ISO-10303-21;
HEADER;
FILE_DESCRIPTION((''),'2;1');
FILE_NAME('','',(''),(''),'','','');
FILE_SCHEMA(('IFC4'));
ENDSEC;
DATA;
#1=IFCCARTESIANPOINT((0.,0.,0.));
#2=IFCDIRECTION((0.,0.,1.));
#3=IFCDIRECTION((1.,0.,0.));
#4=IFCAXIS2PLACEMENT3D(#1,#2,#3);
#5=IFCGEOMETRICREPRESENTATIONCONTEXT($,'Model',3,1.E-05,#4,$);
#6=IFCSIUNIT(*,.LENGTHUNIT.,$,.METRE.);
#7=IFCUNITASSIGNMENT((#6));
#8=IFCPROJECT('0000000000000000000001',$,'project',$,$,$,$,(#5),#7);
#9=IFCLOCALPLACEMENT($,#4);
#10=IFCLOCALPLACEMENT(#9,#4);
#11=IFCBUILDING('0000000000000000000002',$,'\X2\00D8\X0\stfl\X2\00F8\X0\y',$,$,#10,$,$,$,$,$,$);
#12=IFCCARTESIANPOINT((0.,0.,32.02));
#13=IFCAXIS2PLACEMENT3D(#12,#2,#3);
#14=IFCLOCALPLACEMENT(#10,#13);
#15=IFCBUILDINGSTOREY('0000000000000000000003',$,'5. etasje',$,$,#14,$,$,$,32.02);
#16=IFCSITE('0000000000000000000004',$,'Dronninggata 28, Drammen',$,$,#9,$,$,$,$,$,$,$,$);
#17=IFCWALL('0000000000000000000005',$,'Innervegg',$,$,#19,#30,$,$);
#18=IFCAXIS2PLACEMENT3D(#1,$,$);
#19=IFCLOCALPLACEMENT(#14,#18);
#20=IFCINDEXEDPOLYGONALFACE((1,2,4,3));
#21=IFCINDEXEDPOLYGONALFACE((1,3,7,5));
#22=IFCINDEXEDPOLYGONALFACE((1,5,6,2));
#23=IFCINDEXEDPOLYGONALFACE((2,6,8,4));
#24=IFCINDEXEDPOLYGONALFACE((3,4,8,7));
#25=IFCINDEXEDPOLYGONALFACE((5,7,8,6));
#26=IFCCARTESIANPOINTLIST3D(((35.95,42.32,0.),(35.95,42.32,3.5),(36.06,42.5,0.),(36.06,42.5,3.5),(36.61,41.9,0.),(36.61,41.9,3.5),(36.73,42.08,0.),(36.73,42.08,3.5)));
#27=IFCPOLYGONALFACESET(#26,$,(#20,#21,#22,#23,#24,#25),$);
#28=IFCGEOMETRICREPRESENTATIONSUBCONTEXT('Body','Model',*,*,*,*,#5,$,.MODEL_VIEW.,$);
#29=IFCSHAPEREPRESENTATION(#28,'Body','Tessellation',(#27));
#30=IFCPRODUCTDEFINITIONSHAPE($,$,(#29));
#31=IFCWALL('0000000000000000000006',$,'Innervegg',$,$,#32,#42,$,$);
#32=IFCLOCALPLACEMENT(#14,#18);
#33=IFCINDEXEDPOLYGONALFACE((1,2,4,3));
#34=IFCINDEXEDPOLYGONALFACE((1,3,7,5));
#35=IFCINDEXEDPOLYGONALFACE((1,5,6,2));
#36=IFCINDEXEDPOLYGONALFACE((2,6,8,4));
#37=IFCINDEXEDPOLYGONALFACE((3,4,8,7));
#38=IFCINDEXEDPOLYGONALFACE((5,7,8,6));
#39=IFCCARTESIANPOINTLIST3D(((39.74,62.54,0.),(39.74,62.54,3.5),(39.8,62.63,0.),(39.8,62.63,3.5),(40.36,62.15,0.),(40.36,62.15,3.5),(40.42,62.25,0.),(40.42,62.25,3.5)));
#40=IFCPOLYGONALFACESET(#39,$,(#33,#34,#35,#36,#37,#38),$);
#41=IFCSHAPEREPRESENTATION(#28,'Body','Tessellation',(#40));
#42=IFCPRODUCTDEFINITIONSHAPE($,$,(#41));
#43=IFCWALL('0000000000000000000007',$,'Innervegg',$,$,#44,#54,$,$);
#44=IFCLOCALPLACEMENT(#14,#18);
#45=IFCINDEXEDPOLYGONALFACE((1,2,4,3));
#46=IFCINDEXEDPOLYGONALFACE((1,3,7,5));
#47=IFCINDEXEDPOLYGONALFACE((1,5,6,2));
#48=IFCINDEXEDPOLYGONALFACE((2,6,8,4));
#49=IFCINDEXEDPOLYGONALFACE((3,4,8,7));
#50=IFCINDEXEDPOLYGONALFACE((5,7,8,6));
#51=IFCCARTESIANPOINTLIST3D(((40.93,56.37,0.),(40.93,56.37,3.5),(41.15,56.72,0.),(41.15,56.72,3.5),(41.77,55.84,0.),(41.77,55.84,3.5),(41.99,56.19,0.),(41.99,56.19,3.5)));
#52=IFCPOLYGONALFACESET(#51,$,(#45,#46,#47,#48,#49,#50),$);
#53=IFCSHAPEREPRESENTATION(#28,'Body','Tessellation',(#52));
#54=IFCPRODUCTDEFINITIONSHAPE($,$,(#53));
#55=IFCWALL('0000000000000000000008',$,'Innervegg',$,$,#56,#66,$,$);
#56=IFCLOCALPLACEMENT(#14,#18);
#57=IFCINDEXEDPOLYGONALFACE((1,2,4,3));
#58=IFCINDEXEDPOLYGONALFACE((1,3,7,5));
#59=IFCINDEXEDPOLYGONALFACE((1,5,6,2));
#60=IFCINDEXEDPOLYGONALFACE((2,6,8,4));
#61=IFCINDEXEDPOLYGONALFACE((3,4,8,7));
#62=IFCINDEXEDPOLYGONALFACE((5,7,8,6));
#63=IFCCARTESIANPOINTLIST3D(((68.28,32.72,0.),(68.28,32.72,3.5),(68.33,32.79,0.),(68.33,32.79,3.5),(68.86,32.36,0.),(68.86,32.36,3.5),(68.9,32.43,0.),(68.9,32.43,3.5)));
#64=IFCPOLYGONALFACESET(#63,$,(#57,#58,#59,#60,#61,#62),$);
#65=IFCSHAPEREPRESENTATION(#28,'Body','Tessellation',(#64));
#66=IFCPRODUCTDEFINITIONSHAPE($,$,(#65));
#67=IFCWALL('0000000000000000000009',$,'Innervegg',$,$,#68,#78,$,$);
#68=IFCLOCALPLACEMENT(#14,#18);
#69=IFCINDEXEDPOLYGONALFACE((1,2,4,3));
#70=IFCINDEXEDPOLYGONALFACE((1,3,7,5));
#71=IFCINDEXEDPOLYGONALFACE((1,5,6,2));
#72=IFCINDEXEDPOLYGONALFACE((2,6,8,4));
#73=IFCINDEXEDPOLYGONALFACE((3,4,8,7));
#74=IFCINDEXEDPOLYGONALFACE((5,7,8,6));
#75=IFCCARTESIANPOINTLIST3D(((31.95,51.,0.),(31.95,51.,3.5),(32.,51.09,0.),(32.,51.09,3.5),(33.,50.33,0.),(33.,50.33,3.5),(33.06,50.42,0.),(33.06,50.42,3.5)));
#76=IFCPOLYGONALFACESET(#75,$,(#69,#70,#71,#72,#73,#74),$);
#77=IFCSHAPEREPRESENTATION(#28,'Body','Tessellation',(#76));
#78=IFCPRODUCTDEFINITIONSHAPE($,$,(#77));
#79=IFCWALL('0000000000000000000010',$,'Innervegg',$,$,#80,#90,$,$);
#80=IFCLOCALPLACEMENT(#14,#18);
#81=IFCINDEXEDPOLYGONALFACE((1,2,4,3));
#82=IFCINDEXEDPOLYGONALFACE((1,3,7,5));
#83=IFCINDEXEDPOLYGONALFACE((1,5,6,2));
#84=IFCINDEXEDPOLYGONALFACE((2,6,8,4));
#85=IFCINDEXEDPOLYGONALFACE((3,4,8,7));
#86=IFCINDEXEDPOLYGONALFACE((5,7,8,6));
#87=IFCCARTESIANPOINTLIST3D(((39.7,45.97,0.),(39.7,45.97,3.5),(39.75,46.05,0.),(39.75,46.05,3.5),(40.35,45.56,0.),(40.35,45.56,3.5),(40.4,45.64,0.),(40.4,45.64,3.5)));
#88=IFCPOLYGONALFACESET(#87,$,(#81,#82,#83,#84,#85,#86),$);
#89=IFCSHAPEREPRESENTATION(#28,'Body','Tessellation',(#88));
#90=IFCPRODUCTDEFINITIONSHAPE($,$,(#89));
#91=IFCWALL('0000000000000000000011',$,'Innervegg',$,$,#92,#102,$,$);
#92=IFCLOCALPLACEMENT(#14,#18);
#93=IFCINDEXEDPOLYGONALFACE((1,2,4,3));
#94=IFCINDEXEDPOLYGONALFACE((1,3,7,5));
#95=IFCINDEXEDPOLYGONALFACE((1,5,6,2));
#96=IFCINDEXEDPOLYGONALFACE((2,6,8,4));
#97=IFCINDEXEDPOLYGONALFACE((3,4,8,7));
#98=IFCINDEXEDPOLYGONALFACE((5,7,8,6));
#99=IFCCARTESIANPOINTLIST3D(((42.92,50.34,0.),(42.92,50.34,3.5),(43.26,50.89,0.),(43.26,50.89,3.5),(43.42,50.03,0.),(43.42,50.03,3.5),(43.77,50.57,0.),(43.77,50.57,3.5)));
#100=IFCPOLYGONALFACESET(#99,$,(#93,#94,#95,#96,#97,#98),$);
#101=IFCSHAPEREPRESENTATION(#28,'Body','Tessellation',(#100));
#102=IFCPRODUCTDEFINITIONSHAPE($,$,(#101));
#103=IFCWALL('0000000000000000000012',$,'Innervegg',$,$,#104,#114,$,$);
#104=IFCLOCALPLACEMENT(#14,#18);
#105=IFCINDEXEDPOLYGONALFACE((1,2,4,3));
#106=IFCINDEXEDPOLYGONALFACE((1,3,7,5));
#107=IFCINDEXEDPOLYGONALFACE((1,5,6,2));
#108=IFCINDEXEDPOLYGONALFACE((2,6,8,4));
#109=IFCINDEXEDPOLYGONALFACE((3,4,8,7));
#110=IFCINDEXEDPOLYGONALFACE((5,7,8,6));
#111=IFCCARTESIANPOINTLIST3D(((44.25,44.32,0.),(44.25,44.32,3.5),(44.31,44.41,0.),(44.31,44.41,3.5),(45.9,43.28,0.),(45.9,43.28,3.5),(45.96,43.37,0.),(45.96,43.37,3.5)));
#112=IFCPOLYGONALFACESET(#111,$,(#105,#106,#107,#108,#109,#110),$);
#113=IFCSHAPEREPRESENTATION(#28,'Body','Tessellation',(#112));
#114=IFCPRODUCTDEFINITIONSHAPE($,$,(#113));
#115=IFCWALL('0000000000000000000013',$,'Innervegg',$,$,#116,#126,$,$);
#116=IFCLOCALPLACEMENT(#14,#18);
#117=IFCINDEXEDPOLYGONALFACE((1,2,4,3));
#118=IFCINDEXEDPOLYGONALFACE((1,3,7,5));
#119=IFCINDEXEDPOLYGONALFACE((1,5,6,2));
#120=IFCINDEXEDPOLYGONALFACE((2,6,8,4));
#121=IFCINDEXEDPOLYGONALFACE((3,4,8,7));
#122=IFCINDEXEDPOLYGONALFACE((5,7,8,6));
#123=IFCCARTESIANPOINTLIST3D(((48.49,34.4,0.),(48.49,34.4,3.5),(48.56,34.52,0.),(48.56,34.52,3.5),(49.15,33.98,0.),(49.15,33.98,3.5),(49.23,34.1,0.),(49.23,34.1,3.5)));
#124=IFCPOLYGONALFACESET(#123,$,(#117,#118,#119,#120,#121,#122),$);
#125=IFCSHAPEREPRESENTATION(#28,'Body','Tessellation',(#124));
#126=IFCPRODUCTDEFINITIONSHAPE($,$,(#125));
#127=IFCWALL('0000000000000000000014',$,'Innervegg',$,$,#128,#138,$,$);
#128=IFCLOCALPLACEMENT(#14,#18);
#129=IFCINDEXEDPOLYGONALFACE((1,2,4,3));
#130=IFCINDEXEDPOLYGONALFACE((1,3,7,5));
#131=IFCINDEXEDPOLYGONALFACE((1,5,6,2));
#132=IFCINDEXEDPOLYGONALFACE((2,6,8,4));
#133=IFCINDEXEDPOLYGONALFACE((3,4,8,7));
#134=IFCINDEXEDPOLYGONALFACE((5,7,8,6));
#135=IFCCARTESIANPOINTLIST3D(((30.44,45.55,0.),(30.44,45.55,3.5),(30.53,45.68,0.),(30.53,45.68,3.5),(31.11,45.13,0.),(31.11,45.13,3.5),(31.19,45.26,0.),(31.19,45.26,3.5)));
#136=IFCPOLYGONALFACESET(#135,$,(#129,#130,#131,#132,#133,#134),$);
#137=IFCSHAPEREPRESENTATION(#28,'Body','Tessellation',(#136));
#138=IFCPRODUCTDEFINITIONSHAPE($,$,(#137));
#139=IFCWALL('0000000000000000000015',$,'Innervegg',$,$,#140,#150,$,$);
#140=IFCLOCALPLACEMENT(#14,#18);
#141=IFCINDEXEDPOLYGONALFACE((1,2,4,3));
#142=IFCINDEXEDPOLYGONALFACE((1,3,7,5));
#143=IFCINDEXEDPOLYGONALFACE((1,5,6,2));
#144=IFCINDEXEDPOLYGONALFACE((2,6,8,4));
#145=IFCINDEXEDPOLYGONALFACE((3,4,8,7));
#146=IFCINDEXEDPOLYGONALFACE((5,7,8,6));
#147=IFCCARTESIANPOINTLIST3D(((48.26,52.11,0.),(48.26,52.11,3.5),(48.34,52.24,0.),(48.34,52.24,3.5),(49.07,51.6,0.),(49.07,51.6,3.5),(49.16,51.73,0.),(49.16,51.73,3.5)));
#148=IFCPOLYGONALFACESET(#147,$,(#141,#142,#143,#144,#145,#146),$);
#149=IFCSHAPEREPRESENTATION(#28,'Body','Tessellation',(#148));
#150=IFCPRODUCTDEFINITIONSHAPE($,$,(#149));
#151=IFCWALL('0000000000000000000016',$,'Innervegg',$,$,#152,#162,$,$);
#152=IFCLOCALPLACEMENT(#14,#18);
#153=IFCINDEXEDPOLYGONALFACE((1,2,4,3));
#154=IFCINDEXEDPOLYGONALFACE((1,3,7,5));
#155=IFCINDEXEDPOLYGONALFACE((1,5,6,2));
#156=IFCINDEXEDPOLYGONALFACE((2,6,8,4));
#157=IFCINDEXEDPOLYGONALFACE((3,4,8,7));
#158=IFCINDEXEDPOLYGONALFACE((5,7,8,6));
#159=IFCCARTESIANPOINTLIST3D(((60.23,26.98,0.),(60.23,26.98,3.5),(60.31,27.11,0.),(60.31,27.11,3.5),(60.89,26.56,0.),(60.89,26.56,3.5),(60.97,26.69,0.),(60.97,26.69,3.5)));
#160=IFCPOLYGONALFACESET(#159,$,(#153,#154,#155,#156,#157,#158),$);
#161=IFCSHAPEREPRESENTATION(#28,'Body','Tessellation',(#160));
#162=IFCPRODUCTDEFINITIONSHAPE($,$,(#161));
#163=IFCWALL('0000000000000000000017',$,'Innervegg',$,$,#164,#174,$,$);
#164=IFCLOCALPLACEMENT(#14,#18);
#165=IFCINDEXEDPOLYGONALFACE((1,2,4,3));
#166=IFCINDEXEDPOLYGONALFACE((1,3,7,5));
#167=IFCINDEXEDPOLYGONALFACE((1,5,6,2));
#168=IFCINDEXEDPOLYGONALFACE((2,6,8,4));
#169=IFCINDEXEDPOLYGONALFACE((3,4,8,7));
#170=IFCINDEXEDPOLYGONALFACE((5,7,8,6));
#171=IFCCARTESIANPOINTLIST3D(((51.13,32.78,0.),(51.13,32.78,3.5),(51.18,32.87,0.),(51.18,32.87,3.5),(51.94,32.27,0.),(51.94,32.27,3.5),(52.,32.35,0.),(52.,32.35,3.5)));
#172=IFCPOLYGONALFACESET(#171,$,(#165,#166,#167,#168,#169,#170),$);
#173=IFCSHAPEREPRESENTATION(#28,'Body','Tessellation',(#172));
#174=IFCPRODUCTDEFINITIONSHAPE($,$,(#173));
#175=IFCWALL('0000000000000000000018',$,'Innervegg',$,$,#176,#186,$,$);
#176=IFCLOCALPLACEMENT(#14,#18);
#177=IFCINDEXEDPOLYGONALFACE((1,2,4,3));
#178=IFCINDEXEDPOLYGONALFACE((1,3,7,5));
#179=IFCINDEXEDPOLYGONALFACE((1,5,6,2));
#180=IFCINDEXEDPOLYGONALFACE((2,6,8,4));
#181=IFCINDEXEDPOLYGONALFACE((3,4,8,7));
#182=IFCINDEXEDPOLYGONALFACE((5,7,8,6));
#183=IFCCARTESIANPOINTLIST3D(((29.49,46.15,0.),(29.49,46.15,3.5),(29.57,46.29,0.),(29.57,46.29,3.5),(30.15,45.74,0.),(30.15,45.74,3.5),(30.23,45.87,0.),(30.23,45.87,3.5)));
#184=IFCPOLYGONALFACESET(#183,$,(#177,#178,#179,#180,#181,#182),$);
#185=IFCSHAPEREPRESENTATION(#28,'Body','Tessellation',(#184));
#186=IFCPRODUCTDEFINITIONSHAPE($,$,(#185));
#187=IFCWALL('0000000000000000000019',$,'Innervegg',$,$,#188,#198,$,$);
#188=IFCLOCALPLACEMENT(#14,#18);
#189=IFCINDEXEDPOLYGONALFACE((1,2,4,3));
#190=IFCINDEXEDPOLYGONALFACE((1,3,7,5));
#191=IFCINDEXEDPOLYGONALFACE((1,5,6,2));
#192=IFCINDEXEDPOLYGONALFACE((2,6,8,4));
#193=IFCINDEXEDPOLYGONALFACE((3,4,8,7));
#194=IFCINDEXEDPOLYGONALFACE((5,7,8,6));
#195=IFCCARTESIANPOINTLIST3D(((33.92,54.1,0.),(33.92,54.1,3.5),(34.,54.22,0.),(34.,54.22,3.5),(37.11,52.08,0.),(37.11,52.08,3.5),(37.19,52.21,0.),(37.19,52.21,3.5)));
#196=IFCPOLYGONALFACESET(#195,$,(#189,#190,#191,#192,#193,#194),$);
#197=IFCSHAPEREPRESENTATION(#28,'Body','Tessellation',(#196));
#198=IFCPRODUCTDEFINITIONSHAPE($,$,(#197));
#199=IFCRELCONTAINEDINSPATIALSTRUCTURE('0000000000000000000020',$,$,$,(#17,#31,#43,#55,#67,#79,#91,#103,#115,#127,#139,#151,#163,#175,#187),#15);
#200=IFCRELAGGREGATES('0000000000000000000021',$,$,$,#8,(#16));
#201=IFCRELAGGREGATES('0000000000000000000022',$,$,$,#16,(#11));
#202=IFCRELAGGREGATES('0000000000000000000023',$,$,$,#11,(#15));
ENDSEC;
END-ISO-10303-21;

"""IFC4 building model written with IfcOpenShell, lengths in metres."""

from ifc_helpers import new_model, si_unit, frame, origin_with_axes, place, context, subcontext, project, spatial, polyline, outline, extrude, element, save


model = new_model("IFC4")

# Units and contexts
model_context = context("Model", 3, precision=1e-05, world=origin_with_axes())
body_context = subcontext(model_context, "Body", "Model", "MODEL_VIEW")
ifc_project = project(units=[si_unit("LENGTHUNIT", "METRE")], contexts=[model_context])

# Site, building, storey
site_placement = place(None, origin_with_axes())
site = spatial("IfcSite", under=ifc_project, at=site_placement, Name="Dronninggata 28, Drammen")
building_placement = place(site_placement, origin_with_axes())
building = spatial("IfcBuilding", under=site, at=building_placement, Name="Østfløy")
storey_placement = place(building_placement, frame((0.0, 0.0, 32.02), z_axis=(0.0, 0.0, 1.0), x_axis=(1.0, 0.0, 0.0)))
storey = spatial("IfcBuildingStorey", under=building, at=storey_placement, Name="5. etasje", Elevation=32.02)

# Walls
wall_1_placement = place(storey_placement, frame((0.0, 0.0, -32.02), z_axis=(0.0, 0.0, 1.0), x_axis=(1.0, 0.0, 0.0)))
element("IfcWall", 1, at=wall_1_placement, inside=storey, Name="Innervegg", context=body_context, shape_type="SweptSolid", body=[
    extrude(outline(polyline([(36.73, 42.08), (36.61, 41.9), (35.95, 42.32), (36.06, 42.5), (36.73, 42.08)])), frame((0.0, 0.0, 32.02)), (0.0, 0.0, 1.0), 3.5),
])
wall_2_placement = place(storey_placement, frame((0.0, 0.0, -32.02), z_axis=(0.0, 0.0, 1.0), x_axis=(1.0, 0.0, 0.0)))
element("IfcWall", 2, at=wall_2_placement, inside=storey, Name="Innervegg", context=body_context, shape_type="SweptSolid", body=[
    extrude(outline(polyline([(40.42, 62.25), (40.36, 62.15), (39.74, 62.54), (39.8, 62.63), (40.42, 62.25)])), frame((0.0, 0.0, 32.02)), (0.0, 0.0, 1.0), 3.5),
])
wall_3_placement = place(storey_placement, frame((0.0, 0.0, -32.02), z_axis=(0.0, 0.0, 1.0), x_axis=(1.0, 0.0, 0.0)))
element("IfcWall", 3, at=wall_3_placement, inside=storey, Name="Innervegg", context=body_context, shape_type="SweptSolid", body=[
    extrude(outline(polyline([(41.99, 56.19), (41.77, 55.84), (40.93, 56.37), (41.15, 56.72), (41.99, 56.19)])), frame((0.0, 0.0, 32.02)), (0.0, 0.0, 1.0), 3.5),
])
wall_4_placement = place(storey_placement, frame((0.0, 0.0, -32.02), z_axis=(0.0, 0.0, 1.0), x_axis=(1.0, 0.0, 0.0)))
element("IfcWall", 4, at=wall_4_placement, inside=storey, Name="Innervegg", context=body_context, shape_type="SweptSolid", body=[
    extrude(outline(polyline([(68.9, 32.43), (68.86, 32.36), (68.28, 32.72), (68.33, 32.79), (68.9, 32.43)])), frame((0.0, 0.0, 32.02)), (0.0, 0.0, 1.0), 3.5),
])
wall_5_placement = place(storey_placement, frame((0.0, 0.0, -32.02), z_axis=(0.0, 0.0, 1.0), x_axis=(1.0, 0.0, 0.0)))
element("IfcWall", 5, at=wall_5_placement, inside=storey, Name="Innervegg", context=body_context, shape_type="SweptSolid", body=[
    extrude(outline(polyline([(33.06, 50.42), (33.0, 50.33), (31.95, 51.0), (32.0, 51.09), (33.06, 50.42)])), frame((0.0, 0.0, 32.02)), (0.0, 0.0, 1.0), 3.5),
])
wall_6_placement = place(storey_placement, frame((0.0, 0.0, -32.02), z_axis=(0.0, 0.0, 1.0), x_axis=(1.0, 0.0, 0.0)))
element("IfcWall", 6, at=wall_6_placement, inside=storey, Name="Innervegg", context=body_context, shape_type="SweptSolid", body=[
    extrude(outline(polyline([(40.4, 45.64), (40.35, 45.56), (39.7, 45.97), (39.75, 46.05), (40.4, 45.64)])), frame((0.0, 0.0, 32.02)), (0.0, 0.0, 1.0), 3.5),
])
wall_7_placement = place(storey_placement, frame((0.0, 0.0, -32.02), z_axis=(0.0, 0.0, 1.0), x_axis=(1.0, 0.0, 0.0)))
element("IfcWall", 7, at=wall_7_placement, inside=storey, Name="Innervegg", context=body_context, shape_type="SweptSolid", body=[
    extrude(outline(polyline([(43.77, 50.57), (43.42, 50.03), (42.92, 50.34), (43.26, 50.89), (43.77, 50.57)])), frame((0.0, 0.0, 32.02)), (0.0, 0.0, 1.0), 3.5),
])
wall_8_placement = place(storey_placement, frame((0.0, 0.0, -32.02), z_axis=(0.0, 0.0, 1.0), x_axis=(1.0, 0.0, 0.0)))
element("IfcWall", 8, at=wall_8_placement, inside=storey, Name="Innervegg", context=body_context, shape_type="SweptSolid", body=[
    extrude(outline(polyline([(45.96, 43.37), (45.9, 43.28), (44.25, 44.32), (44.31, 44.41), (45.96, 43.37)])), frame((0.0, 0.0, 32.02)), (0.0, 0.0, 1.0), 3.5),
])
wall_9_placement = place(storey_placement, frame((0.0, 0.0, -32.02), z_axis=(0.0, 0.0, 1.0), x_axis=(1.0, 0.0, 0.0)))
element("IfcWall", 9, at=wall_9_placement, inside=storey, Name="Innervegg", context=body_context, shape_type="SweptSolid", body=[
    extrude(outline(polyline([(49.23, 34.1), (49.15, 33.98), (48.49, 34.4), (48.56, 34.52), (49.23, 34.1)])), frame((0.0, 0.0, 32.02)), (0.0, 0.0, 1.0), 3.5),
])
wall_10_placement = place(storey_placement, frame((0.0, 0.0, -32.02), z_axis=(0.0, 0.0, 1.0), x_axis=(1.0, 0.0, 0.0)))
element("IfcWall", 10, at=wall_10_placement, inside=storey, Name="Innervegg", context=body_context, shape_type="SweptSolid", body=[
    extrude(outline(polyline([(31.19, 45.26), (31.11, 45.13), (30.44, 45.55), (30.53, 45.68), (31.19, 45.26)])), frame((0.0, 0.0, 32.02)), (0.0, 0.0, 1.0), 3.5),
])
wall_11_placement = place(storey_placement, frame((0.0, 0.0, -32.02), z_axis=(0.0, 0.0, 1.0), x_axis=(1.0, 0.0, 0.0)))
element("IfcWall", 11, at=wall_11_placement, inside=storey, Name="Innervegg", context=body_context, shape_type="SweptSolid", body=[
    extrude(outline(polyline([(49.16, 51.73), (49.07, 51.6), (48.26, 52.11), (48.34, 52.24), (49.16, 51.73)])), frame((0.0, 0.0, 32.02)), (0.0, 0.0, 1.0), 3.5),
])
wall_12_placement = place(storey_placement, frame((0.0, 0.0, -32.02), z_axis=(0.0, 0.0, 1.0), x_axis=(1.0, 0.0, 0.0)))
element("IfcWall", 12, at=wall_12_placement, inside=storey, Name="Innervegg", context=body_context, shape_type="SweptSolid", body=[
    extrude(outline(polyline([(60.97, 26.69), (60.89, 26.56), (60.23, 26.98), (60.31, 27.11), (60.97, 26.69)])), frame((0.0, 0.0, 32.02)), (0.0, 0.0, 1.0), 3.5),
])
wall_13_placement = place(storey_placement, frame((0.0, 0.0, -32.02), z_axis=(0.0, 0.0, 1.0), x_axis=(1.0, 0.0, 0.0)))
element("IfcWall", 13, at=wall_13_placement, inside=storey, Name="Innervegg", context=body_context, shape_type="SweptSolid", body=[
    extrude(outline(polyline([(52.0, 32.35), (51.94, 32.27), (51.13, 32.78), (51.18, 32.87), (52.0, 32.35)])), frame((0.0, 0.0, 32.02)), (0.0, 0.0, 1.0), 3.5),
])
wall_14_placement = place(storey_placement, frame((0.0, 0.0, -32.02), z_axis=(0.0, 0.0, 1.0), x_axis=(1.0, 0.0, 0.0)))
element("IfcWall", 14, at=wall_14_placement, inside=storey, Name="Innervegg", context=body_context, shape_type="SweptSolid", body=[
    extrude(outline(polyline([(30.23, 45.87), (30.15, 45.74), (29.49, 46.15), (29.57, 46.29), (30.23, 45.87)])), frame((0.0, 0.0, 32.02)), (0.0, 0.0, 1.0), 3.5),
])
wall_15_placement = place(storey_placement, frame((0.0, 0.0, -32.02), z_axis=(0.0, 0.0, 1.0), x_axis=(1.0, 0.0, 0.0)))
element("IfcWall", 15, at=wall_15_placement, inside=storey, Name="Innervegg", context=body_context, shape_type="SweptSolid", body=[
    extrude(outline(polyline([(37.19, 52.21), (37.11, 52.08), (33.92, 54.1), (34.0, 54.22), (37.19, 52.21)])), frame((0.0, 0.0, 32.02)), (0.0, 0.0, 1.0), 3.5),
])

save(model, "model.ifc")
